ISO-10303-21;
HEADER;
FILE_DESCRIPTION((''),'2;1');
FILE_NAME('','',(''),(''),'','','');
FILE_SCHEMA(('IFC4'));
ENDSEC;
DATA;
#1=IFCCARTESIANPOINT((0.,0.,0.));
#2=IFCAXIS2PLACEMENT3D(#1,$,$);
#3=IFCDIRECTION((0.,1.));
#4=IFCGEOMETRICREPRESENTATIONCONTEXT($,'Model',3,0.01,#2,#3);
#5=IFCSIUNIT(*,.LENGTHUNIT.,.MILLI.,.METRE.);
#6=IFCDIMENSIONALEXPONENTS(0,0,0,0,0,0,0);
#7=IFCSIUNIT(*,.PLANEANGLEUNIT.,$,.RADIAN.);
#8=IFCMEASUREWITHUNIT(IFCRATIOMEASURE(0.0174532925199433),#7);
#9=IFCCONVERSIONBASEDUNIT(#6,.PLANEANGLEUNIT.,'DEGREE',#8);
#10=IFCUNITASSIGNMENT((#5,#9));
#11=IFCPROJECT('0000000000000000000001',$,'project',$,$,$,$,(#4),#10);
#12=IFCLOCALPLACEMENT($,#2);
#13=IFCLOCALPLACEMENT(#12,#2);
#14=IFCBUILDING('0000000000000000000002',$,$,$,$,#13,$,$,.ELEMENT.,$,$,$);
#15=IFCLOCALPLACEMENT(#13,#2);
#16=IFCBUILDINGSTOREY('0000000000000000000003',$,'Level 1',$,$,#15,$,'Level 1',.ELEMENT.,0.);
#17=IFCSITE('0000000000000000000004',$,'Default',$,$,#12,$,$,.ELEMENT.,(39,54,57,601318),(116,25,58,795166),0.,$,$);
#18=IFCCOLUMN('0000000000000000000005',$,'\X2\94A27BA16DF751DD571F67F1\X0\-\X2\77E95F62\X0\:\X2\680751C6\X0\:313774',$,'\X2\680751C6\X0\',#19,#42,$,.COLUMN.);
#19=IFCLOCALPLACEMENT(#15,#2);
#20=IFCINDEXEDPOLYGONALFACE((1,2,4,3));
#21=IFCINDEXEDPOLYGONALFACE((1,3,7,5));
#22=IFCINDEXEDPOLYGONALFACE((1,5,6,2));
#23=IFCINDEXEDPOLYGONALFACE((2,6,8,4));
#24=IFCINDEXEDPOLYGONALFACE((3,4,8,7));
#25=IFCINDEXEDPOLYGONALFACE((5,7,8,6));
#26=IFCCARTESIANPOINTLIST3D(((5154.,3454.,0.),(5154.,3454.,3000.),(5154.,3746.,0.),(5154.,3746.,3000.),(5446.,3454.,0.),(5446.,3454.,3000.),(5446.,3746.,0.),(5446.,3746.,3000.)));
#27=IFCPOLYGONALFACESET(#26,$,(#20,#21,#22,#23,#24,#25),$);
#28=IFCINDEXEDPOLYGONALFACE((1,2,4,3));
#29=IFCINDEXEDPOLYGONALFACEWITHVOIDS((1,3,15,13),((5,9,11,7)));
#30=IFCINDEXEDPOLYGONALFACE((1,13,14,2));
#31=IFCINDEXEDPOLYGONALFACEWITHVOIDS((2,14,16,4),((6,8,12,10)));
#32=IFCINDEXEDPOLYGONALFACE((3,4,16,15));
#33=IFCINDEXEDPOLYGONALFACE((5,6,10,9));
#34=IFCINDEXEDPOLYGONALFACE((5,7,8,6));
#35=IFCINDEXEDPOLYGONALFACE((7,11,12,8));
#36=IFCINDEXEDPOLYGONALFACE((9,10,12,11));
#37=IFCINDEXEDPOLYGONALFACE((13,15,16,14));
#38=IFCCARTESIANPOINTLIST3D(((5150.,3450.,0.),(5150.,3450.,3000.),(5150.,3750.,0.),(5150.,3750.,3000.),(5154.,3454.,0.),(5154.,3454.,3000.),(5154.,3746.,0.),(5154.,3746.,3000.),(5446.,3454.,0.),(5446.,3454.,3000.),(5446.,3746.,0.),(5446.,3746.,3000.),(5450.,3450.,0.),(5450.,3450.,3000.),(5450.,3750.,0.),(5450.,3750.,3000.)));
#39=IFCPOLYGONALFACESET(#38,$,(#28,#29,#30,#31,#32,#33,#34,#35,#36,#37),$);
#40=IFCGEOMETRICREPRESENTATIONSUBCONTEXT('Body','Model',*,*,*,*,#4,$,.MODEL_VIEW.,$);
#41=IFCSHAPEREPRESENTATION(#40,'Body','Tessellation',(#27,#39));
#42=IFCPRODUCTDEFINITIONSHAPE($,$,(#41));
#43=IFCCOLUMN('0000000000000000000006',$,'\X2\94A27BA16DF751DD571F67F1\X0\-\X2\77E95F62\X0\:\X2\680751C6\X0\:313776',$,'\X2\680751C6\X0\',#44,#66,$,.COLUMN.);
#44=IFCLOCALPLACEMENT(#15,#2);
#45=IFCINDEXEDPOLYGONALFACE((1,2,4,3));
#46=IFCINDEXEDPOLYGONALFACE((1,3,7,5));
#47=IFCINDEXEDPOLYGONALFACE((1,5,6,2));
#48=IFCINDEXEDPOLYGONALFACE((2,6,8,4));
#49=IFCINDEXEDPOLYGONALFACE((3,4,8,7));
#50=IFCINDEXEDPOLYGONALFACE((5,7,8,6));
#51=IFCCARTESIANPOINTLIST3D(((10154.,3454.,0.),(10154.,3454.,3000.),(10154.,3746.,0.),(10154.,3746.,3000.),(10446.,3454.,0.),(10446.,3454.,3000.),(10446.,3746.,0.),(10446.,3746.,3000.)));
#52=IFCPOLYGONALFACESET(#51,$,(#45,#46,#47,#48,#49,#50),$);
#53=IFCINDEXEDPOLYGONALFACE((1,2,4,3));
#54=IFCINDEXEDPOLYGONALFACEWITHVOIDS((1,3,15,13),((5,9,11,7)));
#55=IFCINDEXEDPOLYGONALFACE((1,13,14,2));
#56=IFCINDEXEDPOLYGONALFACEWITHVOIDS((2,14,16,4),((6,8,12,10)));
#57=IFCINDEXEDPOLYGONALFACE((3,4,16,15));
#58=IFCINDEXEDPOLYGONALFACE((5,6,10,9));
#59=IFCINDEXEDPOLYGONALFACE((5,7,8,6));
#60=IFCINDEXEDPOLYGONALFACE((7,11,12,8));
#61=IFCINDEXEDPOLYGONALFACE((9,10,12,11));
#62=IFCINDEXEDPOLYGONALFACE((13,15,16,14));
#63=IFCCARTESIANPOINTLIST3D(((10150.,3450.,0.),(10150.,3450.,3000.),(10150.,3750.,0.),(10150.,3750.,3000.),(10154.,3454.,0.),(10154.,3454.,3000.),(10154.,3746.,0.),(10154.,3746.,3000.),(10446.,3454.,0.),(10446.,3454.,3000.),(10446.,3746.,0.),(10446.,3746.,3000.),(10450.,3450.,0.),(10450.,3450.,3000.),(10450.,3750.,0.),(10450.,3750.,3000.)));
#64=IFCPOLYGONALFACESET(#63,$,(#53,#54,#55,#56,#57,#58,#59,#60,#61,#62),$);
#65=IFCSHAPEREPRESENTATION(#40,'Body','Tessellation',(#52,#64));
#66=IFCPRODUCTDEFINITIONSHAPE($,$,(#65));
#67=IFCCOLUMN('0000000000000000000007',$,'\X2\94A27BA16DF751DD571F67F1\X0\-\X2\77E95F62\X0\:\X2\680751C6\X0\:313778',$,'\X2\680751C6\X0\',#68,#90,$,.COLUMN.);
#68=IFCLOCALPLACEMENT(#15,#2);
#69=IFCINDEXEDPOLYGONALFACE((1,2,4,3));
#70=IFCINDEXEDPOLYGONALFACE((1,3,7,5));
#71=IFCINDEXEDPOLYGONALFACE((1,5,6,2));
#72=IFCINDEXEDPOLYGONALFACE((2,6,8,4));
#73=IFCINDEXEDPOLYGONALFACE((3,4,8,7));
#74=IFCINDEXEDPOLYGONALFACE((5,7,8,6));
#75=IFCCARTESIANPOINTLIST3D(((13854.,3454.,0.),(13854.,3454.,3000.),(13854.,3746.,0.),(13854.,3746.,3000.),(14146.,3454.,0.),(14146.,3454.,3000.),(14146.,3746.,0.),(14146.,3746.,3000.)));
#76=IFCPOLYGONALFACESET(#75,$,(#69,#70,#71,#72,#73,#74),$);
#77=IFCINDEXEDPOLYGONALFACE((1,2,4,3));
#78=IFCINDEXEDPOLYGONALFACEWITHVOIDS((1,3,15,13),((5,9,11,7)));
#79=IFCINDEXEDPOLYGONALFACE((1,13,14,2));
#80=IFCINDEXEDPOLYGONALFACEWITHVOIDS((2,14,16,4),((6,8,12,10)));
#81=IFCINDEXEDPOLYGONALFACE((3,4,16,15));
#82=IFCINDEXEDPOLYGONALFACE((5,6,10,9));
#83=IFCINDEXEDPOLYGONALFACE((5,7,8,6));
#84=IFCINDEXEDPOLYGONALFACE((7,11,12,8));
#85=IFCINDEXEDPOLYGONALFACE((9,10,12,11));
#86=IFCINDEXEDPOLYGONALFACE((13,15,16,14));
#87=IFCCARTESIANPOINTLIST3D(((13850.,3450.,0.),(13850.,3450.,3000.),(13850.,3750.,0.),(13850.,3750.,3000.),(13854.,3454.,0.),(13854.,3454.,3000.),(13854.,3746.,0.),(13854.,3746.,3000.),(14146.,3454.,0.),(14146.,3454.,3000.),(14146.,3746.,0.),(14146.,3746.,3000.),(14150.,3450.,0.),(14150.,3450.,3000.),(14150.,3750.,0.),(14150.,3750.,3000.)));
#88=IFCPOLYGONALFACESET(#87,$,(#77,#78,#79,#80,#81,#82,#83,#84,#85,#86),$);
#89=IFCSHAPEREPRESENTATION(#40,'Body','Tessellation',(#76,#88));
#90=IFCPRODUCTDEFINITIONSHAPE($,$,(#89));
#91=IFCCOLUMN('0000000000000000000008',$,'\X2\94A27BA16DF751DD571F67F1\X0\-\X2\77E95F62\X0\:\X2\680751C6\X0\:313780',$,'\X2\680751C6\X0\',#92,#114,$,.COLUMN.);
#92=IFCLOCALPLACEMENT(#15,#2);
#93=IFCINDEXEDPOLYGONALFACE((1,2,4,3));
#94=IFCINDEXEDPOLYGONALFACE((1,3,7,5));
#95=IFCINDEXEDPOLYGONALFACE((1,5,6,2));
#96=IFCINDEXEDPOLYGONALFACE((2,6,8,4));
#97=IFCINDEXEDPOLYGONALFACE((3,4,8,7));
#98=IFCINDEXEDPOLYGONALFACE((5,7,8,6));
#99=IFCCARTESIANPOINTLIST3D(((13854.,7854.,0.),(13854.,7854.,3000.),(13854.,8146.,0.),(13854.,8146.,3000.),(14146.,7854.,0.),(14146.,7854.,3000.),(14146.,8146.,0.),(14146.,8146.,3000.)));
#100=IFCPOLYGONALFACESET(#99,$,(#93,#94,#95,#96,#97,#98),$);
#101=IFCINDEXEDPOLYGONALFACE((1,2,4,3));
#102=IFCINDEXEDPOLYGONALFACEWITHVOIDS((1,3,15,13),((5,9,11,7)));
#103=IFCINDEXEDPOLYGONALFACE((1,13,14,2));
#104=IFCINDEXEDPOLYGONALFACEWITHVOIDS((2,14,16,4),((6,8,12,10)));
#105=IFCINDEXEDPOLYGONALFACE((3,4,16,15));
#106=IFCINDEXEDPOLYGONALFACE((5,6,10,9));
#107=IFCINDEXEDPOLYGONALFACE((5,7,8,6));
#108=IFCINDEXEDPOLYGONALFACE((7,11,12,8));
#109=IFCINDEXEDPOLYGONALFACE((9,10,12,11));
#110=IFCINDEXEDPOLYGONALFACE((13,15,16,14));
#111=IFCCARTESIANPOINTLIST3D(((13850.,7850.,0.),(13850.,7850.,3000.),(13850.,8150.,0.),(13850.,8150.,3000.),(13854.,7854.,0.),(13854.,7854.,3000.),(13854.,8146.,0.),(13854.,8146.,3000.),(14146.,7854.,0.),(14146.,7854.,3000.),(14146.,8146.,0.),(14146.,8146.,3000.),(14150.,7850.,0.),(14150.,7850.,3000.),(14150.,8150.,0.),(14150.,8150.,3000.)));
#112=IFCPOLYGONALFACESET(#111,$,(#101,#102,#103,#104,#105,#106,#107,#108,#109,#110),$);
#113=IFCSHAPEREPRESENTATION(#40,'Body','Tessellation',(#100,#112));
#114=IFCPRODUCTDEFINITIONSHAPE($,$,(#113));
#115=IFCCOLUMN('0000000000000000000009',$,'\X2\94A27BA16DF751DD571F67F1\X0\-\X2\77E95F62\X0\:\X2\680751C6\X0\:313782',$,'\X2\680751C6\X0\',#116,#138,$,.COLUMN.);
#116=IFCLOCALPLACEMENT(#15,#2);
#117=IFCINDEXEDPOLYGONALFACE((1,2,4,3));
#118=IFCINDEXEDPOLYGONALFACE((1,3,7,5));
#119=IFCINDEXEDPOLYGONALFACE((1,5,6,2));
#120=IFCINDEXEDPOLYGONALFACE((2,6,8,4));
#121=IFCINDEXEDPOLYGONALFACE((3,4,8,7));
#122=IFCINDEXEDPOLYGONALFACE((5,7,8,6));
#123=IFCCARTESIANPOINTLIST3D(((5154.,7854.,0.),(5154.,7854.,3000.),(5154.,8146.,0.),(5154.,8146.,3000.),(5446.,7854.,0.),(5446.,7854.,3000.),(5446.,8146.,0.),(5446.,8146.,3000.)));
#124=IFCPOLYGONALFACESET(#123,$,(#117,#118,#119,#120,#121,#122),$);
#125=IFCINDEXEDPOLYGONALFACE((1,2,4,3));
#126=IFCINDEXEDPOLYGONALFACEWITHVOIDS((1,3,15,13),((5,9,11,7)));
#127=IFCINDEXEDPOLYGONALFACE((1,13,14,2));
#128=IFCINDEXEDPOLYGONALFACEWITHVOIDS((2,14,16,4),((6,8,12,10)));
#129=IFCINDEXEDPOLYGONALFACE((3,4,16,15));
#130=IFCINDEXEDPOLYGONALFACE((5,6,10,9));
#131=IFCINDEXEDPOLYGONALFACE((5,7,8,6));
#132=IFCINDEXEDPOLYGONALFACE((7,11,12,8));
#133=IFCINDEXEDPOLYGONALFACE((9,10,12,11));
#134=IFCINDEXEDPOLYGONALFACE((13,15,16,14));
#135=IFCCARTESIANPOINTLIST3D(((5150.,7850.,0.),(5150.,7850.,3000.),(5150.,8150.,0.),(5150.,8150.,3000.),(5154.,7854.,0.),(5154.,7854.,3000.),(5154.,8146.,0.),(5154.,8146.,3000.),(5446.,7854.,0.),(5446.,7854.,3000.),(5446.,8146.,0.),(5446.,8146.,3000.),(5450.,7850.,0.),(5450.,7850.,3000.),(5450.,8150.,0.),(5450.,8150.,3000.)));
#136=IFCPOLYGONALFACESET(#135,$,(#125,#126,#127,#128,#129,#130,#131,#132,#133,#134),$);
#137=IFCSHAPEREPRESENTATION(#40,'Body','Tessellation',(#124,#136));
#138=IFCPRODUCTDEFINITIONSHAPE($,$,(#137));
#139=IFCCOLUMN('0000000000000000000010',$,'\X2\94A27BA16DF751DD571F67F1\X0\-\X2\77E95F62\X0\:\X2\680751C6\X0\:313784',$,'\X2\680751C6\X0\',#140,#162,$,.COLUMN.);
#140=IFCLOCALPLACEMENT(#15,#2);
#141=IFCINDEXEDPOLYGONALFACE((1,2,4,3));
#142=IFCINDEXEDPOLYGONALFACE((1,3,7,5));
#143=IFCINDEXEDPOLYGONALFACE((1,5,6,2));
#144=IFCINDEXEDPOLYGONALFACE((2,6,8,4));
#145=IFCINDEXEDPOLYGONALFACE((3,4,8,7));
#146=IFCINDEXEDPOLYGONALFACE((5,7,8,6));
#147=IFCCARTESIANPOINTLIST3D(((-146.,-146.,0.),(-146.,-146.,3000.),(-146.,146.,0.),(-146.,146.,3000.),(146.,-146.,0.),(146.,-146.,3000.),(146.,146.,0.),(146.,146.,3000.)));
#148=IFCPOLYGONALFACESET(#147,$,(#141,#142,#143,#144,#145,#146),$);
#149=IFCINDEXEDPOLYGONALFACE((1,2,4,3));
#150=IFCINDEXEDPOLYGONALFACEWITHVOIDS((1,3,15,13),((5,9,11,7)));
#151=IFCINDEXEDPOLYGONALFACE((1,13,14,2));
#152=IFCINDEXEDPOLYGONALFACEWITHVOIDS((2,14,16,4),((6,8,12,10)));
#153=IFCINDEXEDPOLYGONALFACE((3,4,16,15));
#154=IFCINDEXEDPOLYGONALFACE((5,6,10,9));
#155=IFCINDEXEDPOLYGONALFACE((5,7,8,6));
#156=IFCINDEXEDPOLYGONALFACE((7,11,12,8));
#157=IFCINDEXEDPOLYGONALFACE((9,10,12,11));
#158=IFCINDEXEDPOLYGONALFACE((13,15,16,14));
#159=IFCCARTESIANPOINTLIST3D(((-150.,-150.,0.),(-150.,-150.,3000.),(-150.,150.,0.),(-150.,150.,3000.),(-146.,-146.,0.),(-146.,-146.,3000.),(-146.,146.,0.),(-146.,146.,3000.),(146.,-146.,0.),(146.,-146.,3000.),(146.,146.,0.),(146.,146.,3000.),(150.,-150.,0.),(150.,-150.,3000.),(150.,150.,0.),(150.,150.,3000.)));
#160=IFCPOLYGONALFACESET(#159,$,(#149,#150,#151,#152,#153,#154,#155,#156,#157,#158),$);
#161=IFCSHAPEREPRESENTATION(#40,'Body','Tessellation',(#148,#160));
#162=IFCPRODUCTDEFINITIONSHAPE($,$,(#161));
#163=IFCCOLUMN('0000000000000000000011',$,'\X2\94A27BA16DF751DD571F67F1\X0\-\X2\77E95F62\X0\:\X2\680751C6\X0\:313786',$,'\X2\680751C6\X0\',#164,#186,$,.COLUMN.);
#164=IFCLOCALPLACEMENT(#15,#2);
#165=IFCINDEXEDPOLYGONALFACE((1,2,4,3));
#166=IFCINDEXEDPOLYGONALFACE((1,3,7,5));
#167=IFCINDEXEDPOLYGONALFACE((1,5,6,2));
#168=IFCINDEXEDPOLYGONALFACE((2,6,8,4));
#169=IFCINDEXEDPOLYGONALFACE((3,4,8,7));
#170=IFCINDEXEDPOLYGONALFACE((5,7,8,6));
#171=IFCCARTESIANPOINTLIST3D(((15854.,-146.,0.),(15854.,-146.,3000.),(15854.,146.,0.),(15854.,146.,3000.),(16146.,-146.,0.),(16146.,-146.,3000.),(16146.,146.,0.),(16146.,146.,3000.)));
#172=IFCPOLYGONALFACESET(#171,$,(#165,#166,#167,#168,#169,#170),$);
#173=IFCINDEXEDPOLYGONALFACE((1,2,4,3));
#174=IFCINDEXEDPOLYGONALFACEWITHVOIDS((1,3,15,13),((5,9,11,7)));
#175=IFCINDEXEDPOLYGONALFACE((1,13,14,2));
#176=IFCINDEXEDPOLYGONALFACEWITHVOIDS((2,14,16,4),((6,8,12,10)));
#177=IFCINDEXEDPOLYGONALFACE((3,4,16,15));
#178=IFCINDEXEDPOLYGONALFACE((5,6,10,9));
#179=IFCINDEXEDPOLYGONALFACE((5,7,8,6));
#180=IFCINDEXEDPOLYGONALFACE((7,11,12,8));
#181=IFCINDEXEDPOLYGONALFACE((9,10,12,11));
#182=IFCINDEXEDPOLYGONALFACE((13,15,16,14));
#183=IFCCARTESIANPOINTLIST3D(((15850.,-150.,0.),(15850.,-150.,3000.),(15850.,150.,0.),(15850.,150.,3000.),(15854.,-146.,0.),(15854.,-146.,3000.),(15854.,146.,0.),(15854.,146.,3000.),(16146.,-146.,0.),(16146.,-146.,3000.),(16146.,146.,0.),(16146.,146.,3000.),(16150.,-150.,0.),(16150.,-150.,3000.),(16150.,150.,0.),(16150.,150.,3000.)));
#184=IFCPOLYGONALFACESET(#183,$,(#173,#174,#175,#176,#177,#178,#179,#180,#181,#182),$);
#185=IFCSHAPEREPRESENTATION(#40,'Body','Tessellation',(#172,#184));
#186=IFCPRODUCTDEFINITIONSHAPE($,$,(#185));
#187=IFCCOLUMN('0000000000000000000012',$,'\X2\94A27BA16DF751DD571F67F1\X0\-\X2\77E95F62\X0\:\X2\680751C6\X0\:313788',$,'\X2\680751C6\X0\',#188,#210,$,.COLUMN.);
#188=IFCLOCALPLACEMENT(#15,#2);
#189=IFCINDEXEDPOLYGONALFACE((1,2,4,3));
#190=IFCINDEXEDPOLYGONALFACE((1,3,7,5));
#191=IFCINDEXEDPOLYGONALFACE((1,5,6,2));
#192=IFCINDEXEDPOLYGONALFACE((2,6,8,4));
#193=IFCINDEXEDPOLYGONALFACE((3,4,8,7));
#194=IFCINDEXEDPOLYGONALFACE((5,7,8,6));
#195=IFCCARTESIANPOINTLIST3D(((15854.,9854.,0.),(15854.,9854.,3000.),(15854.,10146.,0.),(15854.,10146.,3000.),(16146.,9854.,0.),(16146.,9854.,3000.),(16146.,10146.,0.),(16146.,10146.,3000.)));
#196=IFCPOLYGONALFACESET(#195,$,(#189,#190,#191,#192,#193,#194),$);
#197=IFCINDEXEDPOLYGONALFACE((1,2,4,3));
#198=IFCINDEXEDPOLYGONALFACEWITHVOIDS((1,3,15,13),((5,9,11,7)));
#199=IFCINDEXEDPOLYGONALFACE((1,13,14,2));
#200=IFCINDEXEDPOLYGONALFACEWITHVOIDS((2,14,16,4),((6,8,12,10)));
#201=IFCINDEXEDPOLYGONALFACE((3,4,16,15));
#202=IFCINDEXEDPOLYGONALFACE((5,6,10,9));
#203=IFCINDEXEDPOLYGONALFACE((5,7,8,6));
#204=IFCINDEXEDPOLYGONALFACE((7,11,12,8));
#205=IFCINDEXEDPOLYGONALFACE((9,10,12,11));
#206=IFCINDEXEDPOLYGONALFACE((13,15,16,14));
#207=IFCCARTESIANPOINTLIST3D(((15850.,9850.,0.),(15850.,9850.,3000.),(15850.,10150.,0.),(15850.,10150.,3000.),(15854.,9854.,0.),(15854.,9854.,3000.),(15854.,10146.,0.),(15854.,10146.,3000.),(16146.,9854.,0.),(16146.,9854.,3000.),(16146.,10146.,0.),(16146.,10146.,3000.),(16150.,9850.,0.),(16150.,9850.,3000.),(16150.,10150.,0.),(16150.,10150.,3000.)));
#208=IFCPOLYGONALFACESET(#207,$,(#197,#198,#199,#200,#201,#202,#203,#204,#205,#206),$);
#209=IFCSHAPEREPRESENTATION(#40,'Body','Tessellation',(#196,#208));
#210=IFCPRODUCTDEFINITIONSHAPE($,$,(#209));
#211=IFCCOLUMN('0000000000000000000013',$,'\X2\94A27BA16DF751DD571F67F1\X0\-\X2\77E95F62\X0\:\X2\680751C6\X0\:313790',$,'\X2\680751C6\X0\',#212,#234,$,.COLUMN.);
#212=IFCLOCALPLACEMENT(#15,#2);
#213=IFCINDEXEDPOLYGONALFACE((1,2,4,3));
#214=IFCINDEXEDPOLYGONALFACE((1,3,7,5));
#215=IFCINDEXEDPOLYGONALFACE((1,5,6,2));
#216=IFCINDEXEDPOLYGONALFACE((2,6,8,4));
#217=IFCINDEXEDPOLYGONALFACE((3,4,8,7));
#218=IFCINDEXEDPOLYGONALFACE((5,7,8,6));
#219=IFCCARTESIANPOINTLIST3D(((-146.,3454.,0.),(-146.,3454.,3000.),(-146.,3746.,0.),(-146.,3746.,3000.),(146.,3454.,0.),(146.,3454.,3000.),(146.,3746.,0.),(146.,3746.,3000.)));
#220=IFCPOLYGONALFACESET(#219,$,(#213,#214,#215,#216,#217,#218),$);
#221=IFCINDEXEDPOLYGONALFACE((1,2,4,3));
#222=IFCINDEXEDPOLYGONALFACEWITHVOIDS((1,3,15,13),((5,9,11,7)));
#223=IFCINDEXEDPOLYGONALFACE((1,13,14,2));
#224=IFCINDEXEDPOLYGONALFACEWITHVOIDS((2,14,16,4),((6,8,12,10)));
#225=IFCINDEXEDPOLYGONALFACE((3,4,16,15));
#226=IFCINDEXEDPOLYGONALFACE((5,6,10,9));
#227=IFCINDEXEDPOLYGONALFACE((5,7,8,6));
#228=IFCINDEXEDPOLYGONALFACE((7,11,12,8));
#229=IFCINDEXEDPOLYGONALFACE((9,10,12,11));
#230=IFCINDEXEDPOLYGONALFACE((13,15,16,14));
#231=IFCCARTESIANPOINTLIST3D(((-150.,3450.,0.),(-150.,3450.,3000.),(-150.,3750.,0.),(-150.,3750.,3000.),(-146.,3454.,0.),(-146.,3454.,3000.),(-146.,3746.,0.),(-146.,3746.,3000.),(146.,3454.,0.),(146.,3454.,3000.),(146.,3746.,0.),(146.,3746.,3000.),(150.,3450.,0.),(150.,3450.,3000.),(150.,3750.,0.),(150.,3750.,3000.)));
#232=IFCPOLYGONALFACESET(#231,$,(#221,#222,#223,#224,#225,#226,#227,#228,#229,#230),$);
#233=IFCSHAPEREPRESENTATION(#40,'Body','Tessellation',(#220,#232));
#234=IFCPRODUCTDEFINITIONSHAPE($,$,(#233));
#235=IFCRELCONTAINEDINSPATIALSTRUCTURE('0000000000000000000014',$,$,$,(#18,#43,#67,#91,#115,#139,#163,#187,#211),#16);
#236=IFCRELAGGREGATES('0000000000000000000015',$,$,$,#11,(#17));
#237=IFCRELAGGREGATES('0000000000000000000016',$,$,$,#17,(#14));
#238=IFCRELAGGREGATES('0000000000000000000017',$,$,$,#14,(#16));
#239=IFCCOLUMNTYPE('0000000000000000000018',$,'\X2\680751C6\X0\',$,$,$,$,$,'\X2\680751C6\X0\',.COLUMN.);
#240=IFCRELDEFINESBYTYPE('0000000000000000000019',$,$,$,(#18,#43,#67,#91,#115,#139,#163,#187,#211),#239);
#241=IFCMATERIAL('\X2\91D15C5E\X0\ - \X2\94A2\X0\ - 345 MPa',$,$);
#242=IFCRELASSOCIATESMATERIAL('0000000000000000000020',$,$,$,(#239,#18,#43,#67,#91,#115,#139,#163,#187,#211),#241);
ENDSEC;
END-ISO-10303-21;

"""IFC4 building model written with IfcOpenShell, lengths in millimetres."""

from ifc_helpers import new_model, entity, si_unit, converted_unit, direction, frame, origin, origin_2d_with_axis, place, context, subcontext, project, spatial, polyline, rectangle, outline, extrude, source, transform, mapped, material, type_object, type_shapes, element, save


model = new_model("IFC4")

# Units and contexts
model_context = context("Model", 3, precision=0.01, world=origin(), true_north=direction((0.0, 1.0)))
body_context = subcontext(model_context, "Body", "Model", "MODEL_VIEW")
ifc_project = project(units=[si_unit("LENGTHUNIT", "METRE", prefix="MILLI"), converted_unit("PLANEANGLEUNIT", "DEGREE", entity("IfcRatioMeasure", 0.0174532925199433), si_unit("PLANEANGLEUNIT", "RADIAN"), dimensions=[0, 0, 0, 0, 0, 0, 0])], contexts=[model_context])

# Site, building, storey
site_placement = place(None, origin())
site = spatial("IfcSite", under=ifc_project, at=site_placement, Name="Default", CompositionType="ELEMENT", RefLatitude=(39, 54, 57, 601318), RefLongitude=(116, 25, 58, 795166), RefElevation=0.0)
building_placement = place(site_placement, origin())
building = spatial("IfcBuilding", under=site, at=building_placement, CompositionType="ELEMENT")
storey_placement = place(building_placement, origin())
storey = spatial("IfcBuildingStorey", under=building, at=storey_placement, Name="Level 1", LongName="Level 1", CompositionType="ELEMENT", Elevation=0.0)

# Columns
ifc_material_1 = material(Name="金属 - 钢 - 345 MPa")
column_type = type_object("IfcColumnType", Name="标准", ElementType="标准", PredefinedType="COLUMN", material=ifc_material_1)
shared_shape = source(origin(), body_context, "Body", "SweptSolid", [
    extrude(rectangle(XDim=292.0, YDim=292.0, at=origin_2d_with_axis()), frame((0.0, 0.0, 0.0), z_axis=(0.0, 0.0, 1.0), x_axis=(-1.0, 0.0, 0.0)), (0.0, 0.0, 1.0), 3000.0),
    extrude(outline(polyline([(-150.0, -150.0), (150.0, -150.0), (150.0, 150.0), (-150.0, 150.0), (-150.0, -150.0)]), holes=[polyline([(-146.0, -146.0), (-146.0, 146.0), (146.0, 146.0), (146.0, -146.0), (-146.0, -146.0)])]), frame((0.0, 0.0, 0.0), z_axis=(0.0, 0.0, 1.0), x_axis=(-1.0, 0.0, 0.0)), (0.0, 0.0, 1.0), 3000.0),
])
type_shapes(column_type, [shared_shape])
for number, where, name in (
    (1, (5300.0, 3600.0, 0.0), "钢管混凝土柱-矩形:标准:313774"),
    (2, (10300.0, 3600.0, 0.0), "钢管混凝土柱-矩形:标准:313776"),
    (3, (14000.0, 3600.0, 0.0), "钢管混凝土柱-矩形:标准:313778"),
    (4, (14000.0, 8000.0, 0.0), "钢管混凝土柱-矩形:标准:313780"),
    (5, (5300.0, 8000.0, 0.0), "钢管混凝土柱-矩形:标准:313782"),
    (6, (0.0, 0.0, 0.0), "钢管混凝土柱-矩形:标准:313784"),
    (7, (16000.0, 0.0, 0.0), "钢管混凝土柱-矩形:标准:313786"),
    (8, (16000.0, 10000.0, 0.0), "钢管混凝土柱-矩形:标准:313788"),
    (9, (0.0, 3600.0, 0.0), "钢管混凝土柱-矩形:标准:313790"),
):
    element("IfcColumn", number, at=place(storey_placement, frame(where)), inside=storey, type_object=column_type, material=ifc_material_1, Name=name, ObjectType="标准", PredefinedType="COLUMN", context=body_context, shape_type="MappedRepresentation", body=[
        mapped(shared_shape, transform((0.0, 0.0, 0.0), scale=1.0)),
    ])

save(model, "model.ifc")
